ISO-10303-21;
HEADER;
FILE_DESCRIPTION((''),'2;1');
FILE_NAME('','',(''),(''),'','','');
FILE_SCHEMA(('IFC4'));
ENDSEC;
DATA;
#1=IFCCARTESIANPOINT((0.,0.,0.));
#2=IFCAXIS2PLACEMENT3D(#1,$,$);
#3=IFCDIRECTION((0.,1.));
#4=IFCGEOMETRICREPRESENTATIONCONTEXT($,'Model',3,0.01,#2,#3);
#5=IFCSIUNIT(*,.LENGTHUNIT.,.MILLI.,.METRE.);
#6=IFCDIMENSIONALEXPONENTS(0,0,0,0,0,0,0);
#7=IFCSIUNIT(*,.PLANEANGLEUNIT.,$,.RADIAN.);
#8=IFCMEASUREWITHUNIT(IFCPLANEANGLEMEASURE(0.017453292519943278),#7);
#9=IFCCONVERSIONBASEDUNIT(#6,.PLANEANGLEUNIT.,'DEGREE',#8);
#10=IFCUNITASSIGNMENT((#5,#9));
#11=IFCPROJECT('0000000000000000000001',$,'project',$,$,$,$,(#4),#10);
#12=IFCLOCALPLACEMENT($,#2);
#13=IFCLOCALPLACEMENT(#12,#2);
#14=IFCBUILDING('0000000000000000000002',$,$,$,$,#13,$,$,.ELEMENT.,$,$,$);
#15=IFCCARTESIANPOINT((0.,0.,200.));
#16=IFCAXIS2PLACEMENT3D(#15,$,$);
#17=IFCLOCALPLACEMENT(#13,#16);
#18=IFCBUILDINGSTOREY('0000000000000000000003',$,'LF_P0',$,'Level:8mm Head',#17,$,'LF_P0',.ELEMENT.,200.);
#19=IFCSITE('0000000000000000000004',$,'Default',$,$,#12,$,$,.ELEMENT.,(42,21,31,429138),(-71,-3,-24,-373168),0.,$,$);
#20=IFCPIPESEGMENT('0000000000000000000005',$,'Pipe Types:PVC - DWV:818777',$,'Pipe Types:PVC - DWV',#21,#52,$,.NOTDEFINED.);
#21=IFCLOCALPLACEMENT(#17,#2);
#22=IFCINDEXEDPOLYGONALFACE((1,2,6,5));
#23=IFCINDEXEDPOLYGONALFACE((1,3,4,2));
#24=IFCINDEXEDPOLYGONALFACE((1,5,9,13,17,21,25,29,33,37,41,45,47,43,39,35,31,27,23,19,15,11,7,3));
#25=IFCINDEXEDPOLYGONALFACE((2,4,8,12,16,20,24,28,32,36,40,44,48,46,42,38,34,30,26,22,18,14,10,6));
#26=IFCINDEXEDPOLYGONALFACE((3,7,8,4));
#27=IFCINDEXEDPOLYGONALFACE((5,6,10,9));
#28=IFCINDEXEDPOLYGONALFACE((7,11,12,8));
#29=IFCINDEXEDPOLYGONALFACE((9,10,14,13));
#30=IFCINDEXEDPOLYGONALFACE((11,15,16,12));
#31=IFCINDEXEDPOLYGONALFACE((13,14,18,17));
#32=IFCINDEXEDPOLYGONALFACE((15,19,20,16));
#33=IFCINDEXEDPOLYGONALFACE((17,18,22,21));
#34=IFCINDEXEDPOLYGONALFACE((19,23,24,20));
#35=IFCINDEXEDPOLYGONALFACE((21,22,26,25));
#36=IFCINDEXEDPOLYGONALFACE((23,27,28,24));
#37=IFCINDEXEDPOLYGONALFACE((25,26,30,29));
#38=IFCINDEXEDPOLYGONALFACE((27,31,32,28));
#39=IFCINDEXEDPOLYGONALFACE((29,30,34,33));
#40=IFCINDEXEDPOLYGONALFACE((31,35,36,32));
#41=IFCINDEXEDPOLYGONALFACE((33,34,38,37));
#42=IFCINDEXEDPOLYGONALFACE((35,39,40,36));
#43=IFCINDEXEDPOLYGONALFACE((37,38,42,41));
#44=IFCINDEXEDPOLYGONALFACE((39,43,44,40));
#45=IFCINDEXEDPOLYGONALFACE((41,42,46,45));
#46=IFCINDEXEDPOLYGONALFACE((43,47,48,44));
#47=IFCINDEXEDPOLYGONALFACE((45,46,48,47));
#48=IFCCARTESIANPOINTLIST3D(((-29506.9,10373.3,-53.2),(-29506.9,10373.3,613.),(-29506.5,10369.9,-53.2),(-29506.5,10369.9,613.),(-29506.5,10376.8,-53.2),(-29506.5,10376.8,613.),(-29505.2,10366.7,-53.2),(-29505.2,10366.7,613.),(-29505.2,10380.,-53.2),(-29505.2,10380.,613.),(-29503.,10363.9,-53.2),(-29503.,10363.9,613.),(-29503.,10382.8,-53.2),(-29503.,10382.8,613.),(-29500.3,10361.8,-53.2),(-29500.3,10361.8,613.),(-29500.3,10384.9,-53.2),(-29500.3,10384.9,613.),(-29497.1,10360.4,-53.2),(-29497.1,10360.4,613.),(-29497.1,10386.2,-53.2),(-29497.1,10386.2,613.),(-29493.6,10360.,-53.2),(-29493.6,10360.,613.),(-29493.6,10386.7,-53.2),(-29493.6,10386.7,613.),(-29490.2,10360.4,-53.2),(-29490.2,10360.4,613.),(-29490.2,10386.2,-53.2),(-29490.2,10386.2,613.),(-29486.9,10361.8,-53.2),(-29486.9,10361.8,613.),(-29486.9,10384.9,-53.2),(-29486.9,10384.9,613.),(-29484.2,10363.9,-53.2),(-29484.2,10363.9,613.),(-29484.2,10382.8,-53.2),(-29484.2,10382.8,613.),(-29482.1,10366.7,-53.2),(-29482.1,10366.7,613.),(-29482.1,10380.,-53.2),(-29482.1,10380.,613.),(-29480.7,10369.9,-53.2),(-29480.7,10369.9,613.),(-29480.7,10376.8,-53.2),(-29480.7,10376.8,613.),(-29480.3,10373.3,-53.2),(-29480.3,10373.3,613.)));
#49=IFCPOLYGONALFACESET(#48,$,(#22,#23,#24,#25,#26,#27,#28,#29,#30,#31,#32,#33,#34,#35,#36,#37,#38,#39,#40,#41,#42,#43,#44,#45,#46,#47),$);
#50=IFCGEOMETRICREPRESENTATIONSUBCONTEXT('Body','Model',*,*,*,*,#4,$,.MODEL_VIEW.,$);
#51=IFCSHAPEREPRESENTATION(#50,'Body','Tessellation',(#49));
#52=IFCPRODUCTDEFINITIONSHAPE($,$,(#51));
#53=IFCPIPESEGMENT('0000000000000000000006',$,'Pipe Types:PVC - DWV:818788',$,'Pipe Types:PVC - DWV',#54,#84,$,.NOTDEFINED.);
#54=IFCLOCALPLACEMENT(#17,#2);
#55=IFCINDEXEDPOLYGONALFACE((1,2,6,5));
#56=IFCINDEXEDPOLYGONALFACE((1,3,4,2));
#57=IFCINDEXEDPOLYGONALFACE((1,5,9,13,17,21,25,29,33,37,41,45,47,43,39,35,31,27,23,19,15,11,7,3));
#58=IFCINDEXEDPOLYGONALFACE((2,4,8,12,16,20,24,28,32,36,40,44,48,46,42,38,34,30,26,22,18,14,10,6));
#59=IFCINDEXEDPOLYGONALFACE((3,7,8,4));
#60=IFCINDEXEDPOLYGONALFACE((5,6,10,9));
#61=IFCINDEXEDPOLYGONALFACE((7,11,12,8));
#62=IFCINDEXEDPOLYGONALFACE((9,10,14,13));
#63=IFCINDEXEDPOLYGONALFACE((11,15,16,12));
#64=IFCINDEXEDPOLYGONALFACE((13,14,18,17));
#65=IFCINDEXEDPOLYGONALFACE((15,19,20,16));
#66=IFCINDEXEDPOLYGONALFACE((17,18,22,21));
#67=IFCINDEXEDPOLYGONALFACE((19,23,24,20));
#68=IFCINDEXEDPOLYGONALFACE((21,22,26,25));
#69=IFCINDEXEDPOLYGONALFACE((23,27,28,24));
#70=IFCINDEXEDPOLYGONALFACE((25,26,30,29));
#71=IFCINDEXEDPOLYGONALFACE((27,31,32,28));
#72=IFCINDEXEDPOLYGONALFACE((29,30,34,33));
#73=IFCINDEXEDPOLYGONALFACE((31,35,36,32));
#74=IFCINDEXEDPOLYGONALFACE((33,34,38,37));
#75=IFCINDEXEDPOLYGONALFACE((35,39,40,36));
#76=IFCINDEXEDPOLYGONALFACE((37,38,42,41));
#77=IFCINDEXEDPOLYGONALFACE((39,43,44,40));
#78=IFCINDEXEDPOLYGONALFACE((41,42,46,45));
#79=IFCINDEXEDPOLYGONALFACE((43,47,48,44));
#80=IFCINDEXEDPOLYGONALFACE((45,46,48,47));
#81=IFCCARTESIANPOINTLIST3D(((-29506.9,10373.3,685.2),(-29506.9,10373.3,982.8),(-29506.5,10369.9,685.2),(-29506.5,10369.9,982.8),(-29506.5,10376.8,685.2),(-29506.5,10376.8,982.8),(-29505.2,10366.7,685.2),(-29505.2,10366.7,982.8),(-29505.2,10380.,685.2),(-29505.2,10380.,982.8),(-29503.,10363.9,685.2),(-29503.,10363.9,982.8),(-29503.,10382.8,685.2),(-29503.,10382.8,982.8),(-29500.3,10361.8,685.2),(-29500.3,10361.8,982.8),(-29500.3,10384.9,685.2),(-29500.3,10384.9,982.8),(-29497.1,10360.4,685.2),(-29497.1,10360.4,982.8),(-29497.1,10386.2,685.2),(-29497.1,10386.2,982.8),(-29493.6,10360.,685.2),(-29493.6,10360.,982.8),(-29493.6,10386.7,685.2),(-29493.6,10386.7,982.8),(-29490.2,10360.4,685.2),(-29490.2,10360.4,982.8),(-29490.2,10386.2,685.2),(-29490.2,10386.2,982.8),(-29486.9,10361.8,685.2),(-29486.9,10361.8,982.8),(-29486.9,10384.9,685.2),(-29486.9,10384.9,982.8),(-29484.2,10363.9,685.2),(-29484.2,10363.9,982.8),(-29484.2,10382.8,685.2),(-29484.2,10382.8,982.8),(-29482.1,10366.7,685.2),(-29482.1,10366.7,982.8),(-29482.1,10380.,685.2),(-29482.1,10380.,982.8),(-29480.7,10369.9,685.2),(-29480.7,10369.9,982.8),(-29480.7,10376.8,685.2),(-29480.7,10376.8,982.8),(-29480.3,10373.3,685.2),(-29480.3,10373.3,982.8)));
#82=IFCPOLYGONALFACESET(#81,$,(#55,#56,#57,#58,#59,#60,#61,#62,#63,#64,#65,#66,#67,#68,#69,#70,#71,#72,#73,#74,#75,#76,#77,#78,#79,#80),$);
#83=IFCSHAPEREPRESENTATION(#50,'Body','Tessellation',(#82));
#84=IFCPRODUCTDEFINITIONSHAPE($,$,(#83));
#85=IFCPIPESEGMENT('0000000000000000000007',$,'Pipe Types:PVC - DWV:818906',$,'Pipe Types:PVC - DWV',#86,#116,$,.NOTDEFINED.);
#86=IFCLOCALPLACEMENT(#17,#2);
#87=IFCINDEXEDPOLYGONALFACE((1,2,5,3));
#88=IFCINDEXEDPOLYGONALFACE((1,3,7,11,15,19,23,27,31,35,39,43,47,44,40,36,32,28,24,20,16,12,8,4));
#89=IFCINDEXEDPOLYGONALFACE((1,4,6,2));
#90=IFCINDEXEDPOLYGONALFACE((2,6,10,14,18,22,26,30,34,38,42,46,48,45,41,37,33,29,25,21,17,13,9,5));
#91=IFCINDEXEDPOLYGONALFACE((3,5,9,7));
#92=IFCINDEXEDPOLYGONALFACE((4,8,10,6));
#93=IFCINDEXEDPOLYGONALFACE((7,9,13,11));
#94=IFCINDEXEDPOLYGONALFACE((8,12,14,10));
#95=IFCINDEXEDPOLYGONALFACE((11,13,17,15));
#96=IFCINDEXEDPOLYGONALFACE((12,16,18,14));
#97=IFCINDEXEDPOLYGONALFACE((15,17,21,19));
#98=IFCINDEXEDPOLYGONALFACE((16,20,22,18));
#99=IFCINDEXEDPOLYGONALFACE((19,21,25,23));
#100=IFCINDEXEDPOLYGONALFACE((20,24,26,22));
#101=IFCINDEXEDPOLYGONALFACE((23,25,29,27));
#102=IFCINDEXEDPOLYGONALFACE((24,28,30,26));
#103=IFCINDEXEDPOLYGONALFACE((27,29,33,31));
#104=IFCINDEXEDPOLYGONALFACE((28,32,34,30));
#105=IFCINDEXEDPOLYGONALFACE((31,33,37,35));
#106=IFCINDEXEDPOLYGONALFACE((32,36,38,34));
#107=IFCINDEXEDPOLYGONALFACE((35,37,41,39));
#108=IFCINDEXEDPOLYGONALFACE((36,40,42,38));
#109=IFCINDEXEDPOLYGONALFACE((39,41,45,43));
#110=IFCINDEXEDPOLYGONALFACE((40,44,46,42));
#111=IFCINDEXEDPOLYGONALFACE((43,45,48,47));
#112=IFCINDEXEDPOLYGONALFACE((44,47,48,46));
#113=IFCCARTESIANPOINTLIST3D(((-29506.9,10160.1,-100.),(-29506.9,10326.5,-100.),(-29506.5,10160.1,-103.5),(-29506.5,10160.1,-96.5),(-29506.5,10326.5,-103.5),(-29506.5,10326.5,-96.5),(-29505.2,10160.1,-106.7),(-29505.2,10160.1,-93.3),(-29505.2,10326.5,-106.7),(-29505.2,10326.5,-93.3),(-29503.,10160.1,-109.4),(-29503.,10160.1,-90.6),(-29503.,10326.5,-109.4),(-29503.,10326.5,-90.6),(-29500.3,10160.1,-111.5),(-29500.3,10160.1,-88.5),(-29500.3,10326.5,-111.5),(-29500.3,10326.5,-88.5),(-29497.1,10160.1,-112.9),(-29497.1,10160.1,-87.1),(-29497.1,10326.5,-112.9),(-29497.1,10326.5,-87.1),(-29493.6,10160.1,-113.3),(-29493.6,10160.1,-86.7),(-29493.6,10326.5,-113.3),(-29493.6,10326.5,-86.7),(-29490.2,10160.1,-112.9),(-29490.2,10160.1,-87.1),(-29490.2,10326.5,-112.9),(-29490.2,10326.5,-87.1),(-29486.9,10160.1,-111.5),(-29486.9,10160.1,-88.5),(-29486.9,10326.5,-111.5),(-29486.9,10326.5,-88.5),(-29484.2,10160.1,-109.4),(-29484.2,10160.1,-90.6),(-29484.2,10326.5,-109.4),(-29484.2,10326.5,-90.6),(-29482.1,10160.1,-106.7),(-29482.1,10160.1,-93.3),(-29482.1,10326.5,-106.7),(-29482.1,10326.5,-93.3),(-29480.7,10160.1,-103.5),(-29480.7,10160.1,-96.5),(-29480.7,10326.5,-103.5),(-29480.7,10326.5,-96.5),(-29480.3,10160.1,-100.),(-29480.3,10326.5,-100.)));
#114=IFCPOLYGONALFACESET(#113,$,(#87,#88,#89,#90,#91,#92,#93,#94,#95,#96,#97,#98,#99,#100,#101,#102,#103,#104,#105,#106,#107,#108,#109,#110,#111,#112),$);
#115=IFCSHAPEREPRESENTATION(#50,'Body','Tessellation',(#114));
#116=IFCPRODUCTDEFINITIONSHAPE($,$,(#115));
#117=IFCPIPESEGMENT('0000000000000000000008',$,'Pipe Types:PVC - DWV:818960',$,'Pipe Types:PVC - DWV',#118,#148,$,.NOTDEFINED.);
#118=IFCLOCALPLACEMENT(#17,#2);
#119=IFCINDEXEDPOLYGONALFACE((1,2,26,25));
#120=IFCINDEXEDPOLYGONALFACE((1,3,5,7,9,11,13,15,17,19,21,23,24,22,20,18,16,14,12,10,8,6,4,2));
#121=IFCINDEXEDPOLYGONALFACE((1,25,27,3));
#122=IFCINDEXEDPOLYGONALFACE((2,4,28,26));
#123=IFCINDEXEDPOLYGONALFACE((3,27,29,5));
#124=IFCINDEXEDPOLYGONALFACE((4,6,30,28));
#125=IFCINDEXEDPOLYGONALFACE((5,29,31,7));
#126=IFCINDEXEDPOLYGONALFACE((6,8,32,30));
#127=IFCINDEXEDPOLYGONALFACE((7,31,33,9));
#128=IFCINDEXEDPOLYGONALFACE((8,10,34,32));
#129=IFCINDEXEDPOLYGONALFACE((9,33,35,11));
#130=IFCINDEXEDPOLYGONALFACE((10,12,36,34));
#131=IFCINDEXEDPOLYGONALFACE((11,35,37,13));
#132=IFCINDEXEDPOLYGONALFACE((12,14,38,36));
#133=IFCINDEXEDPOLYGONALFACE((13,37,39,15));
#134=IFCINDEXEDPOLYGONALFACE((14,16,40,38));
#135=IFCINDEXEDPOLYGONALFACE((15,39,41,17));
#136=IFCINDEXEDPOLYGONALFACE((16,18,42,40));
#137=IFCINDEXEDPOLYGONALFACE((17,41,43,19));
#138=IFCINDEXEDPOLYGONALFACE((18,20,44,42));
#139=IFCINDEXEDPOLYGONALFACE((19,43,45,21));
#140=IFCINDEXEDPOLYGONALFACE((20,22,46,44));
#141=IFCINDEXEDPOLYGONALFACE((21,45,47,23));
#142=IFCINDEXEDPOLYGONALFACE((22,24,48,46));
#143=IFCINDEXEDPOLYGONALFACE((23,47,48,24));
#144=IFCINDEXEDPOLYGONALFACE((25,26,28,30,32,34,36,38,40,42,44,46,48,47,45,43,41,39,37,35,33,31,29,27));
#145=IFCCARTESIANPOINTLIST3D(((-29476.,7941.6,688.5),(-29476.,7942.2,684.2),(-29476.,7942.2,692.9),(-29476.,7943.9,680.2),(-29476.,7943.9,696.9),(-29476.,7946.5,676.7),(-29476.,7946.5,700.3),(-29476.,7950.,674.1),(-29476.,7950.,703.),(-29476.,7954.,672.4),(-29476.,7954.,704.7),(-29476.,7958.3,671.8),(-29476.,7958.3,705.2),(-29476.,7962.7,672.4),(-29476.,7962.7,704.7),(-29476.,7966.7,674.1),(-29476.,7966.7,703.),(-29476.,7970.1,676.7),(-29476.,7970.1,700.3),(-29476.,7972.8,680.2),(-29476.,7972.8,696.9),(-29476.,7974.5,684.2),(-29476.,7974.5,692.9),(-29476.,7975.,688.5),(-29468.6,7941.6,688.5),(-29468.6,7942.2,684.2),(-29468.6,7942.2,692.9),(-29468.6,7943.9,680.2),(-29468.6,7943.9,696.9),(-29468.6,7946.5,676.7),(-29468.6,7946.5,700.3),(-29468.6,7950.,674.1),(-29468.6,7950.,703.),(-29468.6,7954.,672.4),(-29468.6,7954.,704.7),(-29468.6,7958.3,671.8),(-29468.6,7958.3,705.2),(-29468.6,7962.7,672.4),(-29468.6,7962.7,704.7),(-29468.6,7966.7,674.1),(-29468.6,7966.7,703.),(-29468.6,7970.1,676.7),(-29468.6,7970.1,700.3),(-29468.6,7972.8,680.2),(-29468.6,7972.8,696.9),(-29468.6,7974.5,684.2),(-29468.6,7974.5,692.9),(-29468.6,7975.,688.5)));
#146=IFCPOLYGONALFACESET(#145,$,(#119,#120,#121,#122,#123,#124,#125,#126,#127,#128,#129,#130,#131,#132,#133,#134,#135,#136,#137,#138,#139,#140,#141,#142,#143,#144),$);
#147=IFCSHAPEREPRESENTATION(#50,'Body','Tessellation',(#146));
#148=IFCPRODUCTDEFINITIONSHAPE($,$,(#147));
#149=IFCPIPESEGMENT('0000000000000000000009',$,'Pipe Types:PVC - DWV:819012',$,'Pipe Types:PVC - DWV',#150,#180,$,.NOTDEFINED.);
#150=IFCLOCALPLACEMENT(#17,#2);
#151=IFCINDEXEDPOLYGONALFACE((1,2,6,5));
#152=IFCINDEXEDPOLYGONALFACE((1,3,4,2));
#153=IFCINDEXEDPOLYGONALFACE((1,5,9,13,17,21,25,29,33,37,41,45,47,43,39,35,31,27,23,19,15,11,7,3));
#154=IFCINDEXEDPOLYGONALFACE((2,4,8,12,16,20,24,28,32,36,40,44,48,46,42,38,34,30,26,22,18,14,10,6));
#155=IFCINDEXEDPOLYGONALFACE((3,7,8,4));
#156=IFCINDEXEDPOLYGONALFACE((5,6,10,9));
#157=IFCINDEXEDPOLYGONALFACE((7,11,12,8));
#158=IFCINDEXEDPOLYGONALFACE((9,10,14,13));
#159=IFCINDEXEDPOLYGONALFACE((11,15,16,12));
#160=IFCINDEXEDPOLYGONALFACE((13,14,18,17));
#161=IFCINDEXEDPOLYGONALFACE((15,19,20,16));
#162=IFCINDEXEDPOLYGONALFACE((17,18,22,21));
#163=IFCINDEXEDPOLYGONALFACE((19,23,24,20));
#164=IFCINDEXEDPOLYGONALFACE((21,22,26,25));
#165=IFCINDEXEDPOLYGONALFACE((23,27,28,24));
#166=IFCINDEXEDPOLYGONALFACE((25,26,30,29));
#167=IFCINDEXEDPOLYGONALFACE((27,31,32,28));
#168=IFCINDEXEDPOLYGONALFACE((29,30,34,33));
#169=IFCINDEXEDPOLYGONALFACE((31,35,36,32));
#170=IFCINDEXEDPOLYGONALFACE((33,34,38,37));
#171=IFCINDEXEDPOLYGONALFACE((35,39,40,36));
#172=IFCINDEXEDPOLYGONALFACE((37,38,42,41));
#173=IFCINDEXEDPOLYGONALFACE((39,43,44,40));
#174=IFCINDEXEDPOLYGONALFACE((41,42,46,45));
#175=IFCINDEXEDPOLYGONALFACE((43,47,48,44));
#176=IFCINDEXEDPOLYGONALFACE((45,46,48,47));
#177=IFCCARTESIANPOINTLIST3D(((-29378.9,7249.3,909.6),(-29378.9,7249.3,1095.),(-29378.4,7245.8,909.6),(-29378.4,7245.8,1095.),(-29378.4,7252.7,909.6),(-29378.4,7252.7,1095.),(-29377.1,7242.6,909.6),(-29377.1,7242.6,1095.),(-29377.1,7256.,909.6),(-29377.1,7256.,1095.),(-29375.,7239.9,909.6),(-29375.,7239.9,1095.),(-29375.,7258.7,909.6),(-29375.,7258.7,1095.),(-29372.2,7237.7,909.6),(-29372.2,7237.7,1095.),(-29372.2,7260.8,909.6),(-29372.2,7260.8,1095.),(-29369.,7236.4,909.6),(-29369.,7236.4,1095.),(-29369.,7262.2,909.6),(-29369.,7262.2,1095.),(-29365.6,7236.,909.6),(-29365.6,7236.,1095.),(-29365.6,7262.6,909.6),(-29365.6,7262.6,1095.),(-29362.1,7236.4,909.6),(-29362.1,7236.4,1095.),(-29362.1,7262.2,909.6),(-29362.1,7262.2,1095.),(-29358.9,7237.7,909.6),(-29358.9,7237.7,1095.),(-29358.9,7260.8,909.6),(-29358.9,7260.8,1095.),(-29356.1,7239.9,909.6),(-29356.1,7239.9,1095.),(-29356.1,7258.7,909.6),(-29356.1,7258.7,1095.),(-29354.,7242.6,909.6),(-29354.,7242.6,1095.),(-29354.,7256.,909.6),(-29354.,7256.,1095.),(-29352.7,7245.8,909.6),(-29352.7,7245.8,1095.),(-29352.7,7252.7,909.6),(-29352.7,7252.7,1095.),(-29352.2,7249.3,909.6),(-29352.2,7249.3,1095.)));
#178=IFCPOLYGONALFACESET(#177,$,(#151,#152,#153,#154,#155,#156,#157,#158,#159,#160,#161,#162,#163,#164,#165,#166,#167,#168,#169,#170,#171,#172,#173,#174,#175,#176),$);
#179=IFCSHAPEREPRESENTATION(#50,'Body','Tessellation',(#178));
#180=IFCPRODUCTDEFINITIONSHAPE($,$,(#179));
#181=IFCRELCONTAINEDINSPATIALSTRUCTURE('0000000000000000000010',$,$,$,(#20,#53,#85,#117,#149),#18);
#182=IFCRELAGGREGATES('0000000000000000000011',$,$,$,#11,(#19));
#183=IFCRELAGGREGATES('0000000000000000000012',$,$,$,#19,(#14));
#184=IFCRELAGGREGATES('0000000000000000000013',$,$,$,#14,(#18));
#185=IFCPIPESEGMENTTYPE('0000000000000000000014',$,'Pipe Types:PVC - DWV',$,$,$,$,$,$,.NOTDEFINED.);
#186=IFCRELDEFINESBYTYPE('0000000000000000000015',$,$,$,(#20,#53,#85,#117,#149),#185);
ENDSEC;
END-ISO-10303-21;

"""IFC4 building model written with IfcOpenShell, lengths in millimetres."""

from ifc_helpers import new_model, entity, si_unit, converted_unit, direction, frame, origin, place, context, subcontext, project, spatial, arc, indexed_curve, outline, extrude, type_object, element, save


model = new_model("IFC4")

# Units and contexts
model_context = context("Model", 3, precision=0.01, world=origin(), true_north=direction((0.0, 1.0)))
body_context = subcontext(model_context, "Body", "Model", "MODEL_VIEW")
ifc_project = project(units=[si_unit("LENGTHUNIT", "METRE", prefix="MILLI"), converted_unit("PLANEANGLEUNIT", "DEGREE", entity("IfcPlaneAngleMeasure", 0.017453292519943278), si_unit("PLANEANGLEUNIT", "RADIAN"), dimensions=[0, 0, 0, 0, 0, 0, 0])], contexts=[model_context])

# Site, building, storey
site_placement = place(None, origin())
site = spatial("IfcSite", under=ifc_project, at=site_placement, Name="Default", CompositionType="ELEMENT", RefLatitude=(42, 21, 31, 429138), RefLongitude=(-71, -3, -24, -373168), RefElevation=0.0)
building_placement = place(site_placement, origin())
building = spatial("IfcBuilding", under=site, at=building_placement, CompositionType="ELEMENT")
storey_placement = place(building_placement, frame((0.0, 0.0, 200.0)))
storey = spatial("IfcBuildingStorey", under=building, at=storey_placement, Name="LF_P0", ObjectType="Level:8mm Head", LongName="LF_P0", CompositionType="ELEMENT", Elevation=200.0)

# Pipe segments
pipe_segment_type_1 = type_object("IfcPipeSegmentType", Name="Pipe Types:PVC - DWV", PredefinedType="NOTDEFINED")
pipe_segment_1_placement = place(storey_placement, origin())
element("IfcPipeSegment", 1, at=pipe_segment_1_placement, inside=storey, type_object=pipe_segment_type_1, Name="Pipe Types:PVC - DWV:818777", ObjectType="Pipe Types:PVC - DWV", PredefinedType="NOTDEFINED", context=body_context, shape_type="SweptSolid", body=[
    extrude(outline(indexed_curve([(13.3, 0.0), (9.4, 9.4), (0.0, 13.3), (-9.4, 9.4), (-13.3, 0.0), (-9.4, -9.4), (0.0, -13.3), (9.4, -9.4)], segments=[arc(1, 2, 3), arc(3, 4, 5), arc(5, 6, 7), arc(7, 8, 1)], self_intersect=False)), frame((-29493.6, 10373.3, -53.2)), (0.0, 0.0, 1.0), 666.2),
])
pipe_segment_2_placement = place(storey_placement, origin())
element("IfcPipeSegment", 2, at=pipe_segment_2_placement, inside=storey, type_object=pipe_segment_type_1, Name="Pipe Types:PVC - DWV:818788", ObjectType="Pipe Types:PVC - DWV", PredefinedType="NOTDEFINED", context=body_context, shape_type="SweptSolid", body=[
    extrude(outline(indexed_curve([(13.3, 0.0), (9.4, 9.4), (0.0, 13.3), (-9.4, 9.4), (-13.3, 0.0), (-9.4, -9.4), (0.0, -13.3), (9.4, -9.4)], segments=[arc(1, 2, 3), arc(3, 4, 5), arc(5, 6, 7), arc(7, 8, 1)], self_intersect=False)), frame((-29493.6, 10373.3, 685.2)), (0.0, 0.0, 1.0), 297.6),
])
pipe_segment_3_placement = place(storey_placement, origin())
element("IfcPipeSegment", 3, at=pipe_segment_3_placement, inside=storey, type_object=pipe_segment_type_1, Name="Pipe Types:PVC - DWV:818906", ObjectType="Pipe Types:PVC - DWV", PredefinedType="NOTDEFINED", context=body_context, shape_type="SweptSolid", body=[
    extrude(outline(indexed_curve([(13.3, 0.0), (9.4, 9.4), (0.0, 13.3), (-9.4, 9.4), (-13.3, 0.0), (-9.4, -9.4), (0.0, -13.3), (9.4, -9.4)], segments=[arc(1, 2, 3), arc(3, 4, 5), arc(5, 6, 7), arc(7, 8, 1)], self_intersect=False)), frame((-29493.6, 10160.1, -100.0), z_axis=(0.0, 1.0, 0.0), x_axis=(1.0, 0.0, 0.0)), (0.0, 0.0, 1.0), 166.4),
])
pipe_segment_4_placement = place(storey_placement, origin())
element("IfcPipeSegment", 4, at=pipe_segment_4_placement, inside=storey, type_object=pipe_segment_type_1, Name="Pipe Types:PVC - DWV:818960", ObjectType="Pipe Types:PVC - DWV", PredefinedType="NOTDEFINED", context=body_context, shape_type="SweptSolid", body=[
    extrude(outline(indexed_curve([(16.7, 0.0), (11.8, 11.8), (0.0, 16.7), (-11.8, 11.8), (-16.7, 0.0), (-11.8, -11.8), (0.0, -16.7), (11.8, -11.8)], segments=[arc(1, 2, 3), arc(3, 4, 5), arc(5, 6, 7), arc(7, 8, 1)], self_intersect=False)), frame((-29476.0, 7958.3, 688.5), z_axis=(1.0, 0.0, 0.0), x_axis=(0.0, 1.0, 0.0)), (0.0, 0.0, 1.0), 7.4),
])
pipe_segment_5_placement = place(storey_placement, origin())
element("IfcPipeSegment", 5, at=pipe_segment_5_placement, inside=storey, type_object=pipe_segment_type_1, Name="Pipe Types:PVC - DWV:819012", ObjectType="Pipe Types:PVC - DWV", PredefinedType="NOTDEFINED", context=body_context, shape_type="SweptSolid", body=[
    extrude(outline(indexed_curve([(13.3, 0.0), (9.4, 9.4), (0.0, 13.3), (-9.4, 9.4), (-13.3, 0.0), (-9.4, -9.4), (0.0, -13.3), (9.4, -9.4)], segments=[arc(1, 2, 3), arc(3, 4, 5), arc(5, 6, 7), arc(7, 8, 1)], self_intersect=False)), frame((-29365.6, 7249.3, 909.6), z_axis=(0.0, 0.0, 1.0), x_axis=(-1.0, 0.0, 0.0)), (0.0, 0.0, 1.0), 185.4),
])

save(model, "model.ifc")
